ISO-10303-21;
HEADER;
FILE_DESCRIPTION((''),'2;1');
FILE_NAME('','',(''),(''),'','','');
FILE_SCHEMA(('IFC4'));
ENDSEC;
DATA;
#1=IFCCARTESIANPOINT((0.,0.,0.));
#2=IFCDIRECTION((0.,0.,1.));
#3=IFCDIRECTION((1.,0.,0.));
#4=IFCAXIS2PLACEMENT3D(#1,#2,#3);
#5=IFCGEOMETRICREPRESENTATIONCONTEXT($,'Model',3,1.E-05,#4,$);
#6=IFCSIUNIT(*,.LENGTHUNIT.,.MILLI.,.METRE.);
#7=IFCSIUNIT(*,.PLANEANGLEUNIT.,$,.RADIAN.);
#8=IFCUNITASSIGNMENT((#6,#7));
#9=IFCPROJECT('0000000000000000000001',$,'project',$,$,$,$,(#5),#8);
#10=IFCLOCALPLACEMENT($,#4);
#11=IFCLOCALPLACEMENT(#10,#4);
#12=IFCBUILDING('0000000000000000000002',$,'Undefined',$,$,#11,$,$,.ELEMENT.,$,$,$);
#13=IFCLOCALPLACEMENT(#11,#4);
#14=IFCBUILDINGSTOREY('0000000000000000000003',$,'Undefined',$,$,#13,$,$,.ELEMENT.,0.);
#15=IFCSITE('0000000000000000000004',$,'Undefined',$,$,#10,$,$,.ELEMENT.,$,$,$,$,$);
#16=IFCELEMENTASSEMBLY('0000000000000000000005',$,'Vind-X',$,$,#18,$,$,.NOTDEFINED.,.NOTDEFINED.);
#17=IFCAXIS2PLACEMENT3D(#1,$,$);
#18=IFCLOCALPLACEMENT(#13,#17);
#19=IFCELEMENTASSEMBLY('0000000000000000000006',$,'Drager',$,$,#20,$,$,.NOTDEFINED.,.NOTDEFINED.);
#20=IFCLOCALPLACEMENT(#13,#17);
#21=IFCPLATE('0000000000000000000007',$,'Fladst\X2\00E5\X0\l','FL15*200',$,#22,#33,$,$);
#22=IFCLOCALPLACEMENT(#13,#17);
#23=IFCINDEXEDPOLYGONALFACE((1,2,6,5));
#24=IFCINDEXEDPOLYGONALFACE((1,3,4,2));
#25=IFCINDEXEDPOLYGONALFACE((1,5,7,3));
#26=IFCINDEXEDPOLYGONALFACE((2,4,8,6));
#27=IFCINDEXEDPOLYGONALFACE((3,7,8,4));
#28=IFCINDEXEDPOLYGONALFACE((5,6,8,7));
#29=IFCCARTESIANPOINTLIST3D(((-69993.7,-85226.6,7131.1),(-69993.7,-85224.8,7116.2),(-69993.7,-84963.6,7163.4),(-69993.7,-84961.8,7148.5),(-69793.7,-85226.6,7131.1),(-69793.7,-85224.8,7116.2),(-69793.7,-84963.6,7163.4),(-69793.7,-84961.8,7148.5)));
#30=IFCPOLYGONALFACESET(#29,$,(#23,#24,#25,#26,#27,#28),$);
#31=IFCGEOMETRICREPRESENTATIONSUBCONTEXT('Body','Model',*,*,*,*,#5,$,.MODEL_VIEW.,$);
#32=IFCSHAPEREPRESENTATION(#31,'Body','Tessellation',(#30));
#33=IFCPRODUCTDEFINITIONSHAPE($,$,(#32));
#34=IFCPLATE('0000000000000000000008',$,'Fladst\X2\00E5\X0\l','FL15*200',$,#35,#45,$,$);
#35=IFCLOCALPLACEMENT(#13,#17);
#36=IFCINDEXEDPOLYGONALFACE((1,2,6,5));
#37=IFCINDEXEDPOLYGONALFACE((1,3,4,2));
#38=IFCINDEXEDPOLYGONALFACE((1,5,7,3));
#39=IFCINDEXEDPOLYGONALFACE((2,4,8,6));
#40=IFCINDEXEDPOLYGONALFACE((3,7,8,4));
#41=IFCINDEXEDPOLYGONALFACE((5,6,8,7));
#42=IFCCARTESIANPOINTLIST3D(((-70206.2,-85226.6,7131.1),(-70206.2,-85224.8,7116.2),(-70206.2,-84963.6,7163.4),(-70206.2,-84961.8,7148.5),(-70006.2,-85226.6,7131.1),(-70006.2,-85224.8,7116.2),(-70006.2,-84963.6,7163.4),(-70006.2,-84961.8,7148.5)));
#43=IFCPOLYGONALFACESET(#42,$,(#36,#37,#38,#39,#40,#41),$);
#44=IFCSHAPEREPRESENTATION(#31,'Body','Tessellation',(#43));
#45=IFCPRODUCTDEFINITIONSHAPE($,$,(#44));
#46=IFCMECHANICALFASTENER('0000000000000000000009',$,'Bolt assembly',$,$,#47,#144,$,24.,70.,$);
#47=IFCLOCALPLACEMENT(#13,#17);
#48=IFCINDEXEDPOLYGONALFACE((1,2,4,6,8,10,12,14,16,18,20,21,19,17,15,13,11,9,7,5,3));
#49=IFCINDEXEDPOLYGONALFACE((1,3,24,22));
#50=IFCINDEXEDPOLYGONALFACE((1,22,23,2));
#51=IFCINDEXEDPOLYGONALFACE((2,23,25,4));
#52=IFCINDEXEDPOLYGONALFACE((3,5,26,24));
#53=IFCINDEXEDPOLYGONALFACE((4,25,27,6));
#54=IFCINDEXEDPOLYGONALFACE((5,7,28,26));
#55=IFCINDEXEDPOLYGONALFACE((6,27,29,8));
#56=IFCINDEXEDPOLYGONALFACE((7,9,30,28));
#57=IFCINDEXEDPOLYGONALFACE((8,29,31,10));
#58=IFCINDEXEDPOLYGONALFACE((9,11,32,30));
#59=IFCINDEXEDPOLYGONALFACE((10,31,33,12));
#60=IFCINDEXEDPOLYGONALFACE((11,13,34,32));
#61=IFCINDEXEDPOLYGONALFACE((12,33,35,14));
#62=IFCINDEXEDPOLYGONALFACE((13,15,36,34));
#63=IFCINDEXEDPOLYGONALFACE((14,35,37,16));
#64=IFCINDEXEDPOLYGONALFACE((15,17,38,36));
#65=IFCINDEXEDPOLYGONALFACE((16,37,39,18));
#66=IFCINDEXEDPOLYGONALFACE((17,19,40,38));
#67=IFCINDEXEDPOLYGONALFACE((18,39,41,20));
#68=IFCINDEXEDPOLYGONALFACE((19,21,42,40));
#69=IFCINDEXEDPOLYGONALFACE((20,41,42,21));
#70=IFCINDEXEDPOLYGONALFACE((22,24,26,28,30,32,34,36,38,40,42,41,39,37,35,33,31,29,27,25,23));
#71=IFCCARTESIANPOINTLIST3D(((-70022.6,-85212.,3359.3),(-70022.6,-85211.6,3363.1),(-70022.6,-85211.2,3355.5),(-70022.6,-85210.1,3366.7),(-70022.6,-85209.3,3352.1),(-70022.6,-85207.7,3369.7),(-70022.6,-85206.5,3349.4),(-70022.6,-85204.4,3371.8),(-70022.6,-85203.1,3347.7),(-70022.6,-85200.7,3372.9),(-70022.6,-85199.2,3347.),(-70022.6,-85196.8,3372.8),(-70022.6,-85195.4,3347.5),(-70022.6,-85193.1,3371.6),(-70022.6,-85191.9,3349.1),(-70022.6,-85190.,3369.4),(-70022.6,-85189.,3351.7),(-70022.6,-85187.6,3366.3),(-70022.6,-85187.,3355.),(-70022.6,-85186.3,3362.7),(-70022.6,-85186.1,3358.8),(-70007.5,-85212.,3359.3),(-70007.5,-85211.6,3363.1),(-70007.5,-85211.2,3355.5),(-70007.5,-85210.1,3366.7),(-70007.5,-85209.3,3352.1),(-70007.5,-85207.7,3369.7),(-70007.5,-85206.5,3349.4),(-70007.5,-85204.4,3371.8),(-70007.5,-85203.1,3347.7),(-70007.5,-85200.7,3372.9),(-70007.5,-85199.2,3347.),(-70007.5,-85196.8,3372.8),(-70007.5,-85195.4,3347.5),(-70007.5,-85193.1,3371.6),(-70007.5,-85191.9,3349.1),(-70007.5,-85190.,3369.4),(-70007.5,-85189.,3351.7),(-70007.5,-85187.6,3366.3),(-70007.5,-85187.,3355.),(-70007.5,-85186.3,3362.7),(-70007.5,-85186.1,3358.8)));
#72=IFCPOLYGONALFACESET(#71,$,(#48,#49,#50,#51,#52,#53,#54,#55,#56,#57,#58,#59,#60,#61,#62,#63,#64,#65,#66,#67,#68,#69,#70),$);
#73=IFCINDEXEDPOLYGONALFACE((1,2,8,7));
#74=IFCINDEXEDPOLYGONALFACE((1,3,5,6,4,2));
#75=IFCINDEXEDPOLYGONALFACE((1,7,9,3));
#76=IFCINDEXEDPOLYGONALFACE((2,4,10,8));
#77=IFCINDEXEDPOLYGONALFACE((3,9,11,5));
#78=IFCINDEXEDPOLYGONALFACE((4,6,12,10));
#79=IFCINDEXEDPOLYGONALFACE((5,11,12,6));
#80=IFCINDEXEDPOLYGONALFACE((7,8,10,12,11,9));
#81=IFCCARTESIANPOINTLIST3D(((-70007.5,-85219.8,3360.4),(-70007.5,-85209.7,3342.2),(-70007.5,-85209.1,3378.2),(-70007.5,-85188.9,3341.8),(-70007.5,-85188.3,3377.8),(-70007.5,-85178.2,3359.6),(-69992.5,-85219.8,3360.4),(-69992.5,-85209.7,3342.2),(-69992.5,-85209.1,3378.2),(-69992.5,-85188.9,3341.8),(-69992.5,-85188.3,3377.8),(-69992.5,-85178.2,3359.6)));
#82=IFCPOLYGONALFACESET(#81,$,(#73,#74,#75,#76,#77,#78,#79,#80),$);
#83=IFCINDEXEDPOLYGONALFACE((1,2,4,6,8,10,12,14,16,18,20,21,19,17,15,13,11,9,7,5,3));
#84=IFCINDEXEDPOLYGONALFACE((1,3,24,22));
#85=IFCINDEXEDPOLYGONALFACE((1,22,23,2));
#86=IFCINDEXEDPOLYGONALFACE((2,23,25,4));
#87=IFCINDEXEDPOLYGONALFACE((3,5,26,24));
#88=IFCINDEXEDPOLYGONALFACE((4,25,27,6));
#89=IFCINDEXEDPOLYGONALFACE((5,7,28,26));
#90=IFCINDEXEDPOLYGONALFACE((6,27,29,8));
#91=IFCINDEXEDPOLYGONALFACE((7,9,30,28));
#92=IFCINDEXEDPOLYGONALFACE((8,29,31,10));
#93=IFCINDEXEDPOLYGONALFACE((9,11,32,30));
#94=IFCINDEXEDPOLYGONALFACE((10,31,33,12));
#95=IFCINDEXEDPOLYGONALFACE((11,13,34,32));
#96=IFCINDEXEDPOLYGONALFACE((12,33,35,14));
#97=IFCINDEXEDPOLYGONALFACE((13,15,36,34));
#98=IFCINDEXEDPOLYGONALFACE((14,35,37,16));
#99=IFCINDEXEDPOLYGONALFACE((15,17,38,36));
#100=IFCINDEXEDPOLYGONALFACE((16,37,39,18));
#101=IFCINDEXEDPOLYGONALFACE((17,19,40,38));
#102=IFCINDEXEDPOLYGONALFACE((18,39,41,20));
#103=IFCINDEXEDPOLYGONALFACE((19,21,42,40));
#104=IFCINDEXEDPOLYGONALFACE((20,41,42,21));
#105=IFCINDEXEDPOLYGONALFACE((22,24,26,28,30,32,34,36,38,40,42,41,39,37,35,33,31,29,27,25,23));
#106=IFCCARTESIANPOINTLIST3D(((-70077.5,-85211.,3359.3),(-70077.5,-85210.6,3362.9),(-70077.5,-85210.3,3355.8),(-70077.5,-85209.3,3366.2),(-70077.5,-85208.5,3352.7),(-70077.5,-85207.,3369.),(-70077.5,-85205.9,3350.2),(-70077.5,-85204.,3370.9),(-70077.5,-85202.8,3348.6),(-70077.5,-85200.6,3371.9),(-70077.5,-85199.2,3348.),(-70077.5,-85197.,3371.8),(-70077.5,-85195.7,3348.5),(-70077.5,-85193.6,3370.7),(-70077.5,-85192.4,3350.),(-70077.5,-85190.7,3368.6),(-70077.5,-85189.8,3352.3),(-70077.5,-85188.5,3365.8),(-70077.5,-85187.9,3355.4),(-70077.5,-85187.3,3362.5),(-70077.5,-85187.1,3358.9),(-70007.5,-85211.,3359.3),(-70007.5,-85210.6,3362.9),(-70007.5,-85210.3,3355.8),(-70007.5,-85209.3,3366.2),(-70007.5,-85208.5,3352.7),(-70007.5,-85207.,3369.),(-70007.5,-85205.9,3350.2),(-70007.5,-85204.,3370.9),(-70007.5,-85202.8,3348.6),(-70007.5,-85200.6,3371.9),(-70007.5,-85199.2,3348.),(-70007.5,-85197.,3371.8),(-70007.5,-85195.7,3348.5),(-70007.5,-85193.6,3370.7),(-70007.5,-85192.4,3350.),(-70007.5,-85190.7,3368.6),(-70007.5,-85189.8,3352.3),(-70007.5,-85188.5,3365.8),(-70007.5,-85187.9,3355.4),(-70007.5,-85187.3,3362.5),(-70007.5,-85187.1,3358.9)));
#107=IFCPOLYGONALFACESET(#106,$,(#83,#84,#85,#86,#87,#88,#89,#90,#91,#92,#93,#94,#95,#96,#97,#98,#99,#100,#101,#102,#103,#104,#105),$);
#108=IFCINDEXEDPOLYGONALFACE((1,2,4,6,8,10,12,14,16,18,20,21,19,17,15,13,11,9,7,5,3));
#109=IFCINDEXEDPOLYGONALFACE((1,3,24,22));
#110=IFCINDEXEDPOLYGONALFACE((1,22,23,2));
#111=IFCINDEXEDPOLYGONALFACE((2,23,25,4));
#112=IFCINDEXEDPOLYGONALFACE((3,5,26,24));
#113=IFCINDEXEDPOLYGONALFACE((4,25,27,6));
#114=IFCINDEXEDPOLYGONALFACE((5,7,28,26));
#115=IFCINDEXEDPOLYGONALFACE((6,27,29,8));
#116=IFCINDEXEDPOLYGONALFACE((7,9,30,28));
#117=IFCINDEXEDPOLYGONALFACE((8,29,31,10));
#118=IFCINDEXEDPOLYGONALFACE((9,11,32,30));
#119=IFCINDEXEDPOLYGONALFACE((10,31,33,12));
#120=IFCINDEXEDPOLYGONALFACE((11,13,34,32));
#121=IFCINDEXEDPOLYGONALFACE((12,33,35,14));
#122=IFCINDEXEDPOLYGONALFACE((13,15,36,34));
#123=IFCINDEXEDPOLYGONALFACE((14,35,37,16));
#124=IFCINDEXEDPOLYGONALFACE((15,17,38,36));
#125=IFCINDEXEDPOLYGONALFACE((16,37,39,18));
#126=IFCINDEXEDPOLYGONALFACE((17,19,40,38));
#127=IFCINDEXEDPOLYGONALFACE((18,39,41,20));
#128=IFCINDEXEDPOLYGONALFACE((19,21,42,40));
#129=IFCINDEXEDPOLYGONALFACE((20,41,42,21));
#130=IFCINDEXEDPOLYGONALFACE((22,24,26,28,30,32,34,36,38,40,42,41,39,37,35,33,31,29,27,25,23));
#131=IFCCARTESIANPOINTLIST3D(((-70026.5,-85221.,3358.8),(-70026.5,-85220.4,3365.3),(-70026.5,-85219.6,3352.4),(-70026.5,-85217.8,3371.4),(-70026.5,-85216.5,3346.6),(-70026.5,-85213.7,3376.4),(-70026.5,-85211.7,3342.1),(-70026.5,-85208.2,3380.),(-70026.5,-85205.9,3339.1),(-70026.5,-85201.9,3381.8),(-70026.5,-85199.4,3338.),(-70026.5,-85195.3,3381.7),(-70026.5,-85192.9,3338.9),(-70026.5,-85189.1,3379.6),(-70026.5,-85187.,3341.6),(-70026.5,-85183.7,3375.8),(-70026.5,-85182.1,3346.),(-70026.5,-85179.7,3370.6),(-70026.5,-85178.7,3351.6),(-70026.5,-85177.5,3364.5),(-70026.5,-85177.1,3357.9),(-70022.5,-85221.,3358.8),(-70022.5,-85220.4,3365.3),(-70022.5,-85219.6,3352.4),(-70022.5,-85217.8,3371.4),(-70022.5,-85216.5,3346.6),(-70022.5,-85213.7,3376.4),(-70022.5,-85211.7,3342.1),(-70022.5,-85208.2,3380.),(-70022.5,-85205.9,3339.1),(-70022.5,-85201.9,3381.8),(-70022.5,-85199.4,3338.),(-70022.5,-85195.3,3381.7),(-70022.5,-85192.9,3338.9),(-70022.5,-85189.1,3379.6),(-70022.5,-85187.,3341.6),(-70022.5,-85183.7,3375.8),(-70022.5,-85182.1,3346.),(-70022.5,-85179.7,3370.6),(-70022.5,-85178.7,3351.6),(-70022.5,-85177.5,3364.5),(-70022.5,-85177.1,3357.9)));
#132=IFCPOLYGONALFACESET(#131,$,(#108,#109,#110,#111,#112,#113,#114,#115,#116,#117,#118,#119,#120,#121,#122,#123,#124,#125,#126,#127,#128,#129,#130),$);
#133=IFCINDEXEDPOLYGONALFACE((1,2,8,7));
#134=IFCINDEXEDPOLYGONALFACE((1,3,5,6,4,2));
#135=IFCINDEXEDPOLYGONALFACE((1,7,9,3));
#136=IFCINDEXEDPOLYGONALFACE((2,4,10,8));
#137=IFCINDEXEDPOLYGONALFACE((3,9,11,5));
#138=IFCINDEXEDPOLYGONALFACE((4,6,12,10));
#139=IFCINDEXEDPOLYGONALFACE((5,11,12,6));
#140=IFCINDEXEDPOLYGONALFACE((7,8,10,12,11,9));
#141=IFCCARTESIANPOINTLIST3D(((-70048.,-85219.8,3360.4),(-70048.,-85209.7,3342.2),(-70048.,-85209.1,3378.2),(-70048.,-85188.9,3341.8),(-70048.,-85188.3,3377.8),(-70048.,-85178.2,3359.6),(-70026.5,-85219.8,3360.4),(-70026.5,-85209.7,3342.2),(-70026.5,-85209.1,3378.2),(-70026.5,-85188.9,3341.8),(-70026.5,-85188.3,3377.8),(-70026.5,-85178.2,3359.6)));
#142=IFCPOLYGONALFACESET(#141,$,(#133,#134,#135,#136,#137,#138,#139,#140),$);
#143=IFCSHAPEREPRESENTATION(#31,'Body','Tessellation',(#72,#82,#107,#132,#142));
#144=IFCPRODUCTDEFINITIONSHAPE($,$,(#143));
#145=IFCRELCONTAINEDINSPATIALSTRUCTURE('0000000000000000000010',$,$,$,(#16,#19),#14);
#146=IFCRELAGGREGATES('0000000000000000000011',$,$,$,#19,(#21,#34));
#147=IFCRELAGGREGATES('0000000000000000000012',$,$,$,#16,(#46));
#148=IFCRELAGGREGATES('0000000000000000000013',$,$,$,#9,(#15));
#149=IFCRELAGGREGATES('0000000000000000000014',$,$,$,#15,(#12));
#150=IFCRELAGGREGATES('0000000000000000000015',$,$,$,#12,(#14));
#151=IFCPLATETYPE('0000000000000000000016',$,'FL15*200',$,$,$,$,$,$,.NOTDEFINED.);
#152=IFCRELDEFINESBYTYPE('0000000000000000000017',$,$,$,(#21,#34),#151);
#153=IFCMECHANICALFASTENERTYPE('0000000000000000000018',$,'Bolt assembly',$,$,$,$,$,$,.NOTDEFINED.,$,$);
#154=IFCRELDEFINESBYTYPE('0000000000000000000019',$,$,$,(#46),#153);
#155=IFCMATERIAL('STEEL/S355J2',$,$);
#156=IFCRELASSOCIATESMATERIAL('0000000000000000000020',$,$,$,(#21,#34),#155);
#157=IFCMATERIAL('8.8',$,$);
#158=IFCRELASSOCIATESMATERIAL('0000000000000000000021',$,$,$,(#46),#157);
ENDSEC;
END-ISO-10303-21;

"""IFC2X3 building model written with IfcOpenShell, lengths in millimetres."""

from ifc_helpers import new_model, si_unit, frame, origin_with_axes, origin_2d_with_axis, place, context, subcontext, project, spatial, polyline, circle, outline, extrude, source, transform, mapped, material, type_object, element, aggregate, save


model = new_model("IFC2X3")

# Units and contexts
model_context = context("Model", 3, precision=1e-05, world=origin_with_axes())
body_context = subcontext(model_context, "Body", "Model", "MODEL_VIEW")
ifc_project = project(units=[si_unit("LENGTHUNIT", "METRE", prefix="MILLI"), si_unit("PLANEANGLEUNIT", "RADIAN")], contexts=[model_context])

# Site, building, storey
site_placement = place(None, origin_with_axes())
site = spatial("IfcSite", under=ifc_project, at=site_placement, Name="Undefined", CompositionType="ELEMENT")
building_placement = place(site_placement, origin_with_axes())
building = spatial("IfcBuilding", under=site, at=building_placement, Name="Undefined", CompositionType="ELEMENT")
storey_placement = place(building_placement, origin_with_axes())
storey = spatial("IfcBuildingStorey", under=building, at=storey_placement, Name="Undefined", CompositionType="ELEMENT", Elevation=0.0)

# Element assembly
assembly_1_placement = place(storey_placement, origin_with_axes())
assembly_1 = element("IfcElementAssembly", 1, at=assembly_1_placement, inside=storey, Name="Vind-X", AssemblyPlace="NOTDEFINED", PredefinedType="NOTDEFINED")
ifc_material_1 = material(Name="STEEL/S355J2")

# Element assembly
assembly_2_placement = place(storey_placement, origin_with_axes())
assembly_2 = element("IfcElementAssembly", 2, at=assembly_2_placement, inside=storey, Name="Drager", AssemblyPlace="NOTDEFINED", PredefinedType="NOTDEFINED")

# Plates
plate_type_1 = type_object("IfcPlateType", Name="FL15*200", PredefinedType="NOTDEFINED")
plate_1_placement = place(assembly_2_placement, frame((-69993.7, -84962.7, 7155.9), z_axis=(0.0, -0.121869, 0.992546), x_axis=(0.0, -0.992546, -0.121869)))
plate_1 = element("IfcPlate", 3, at=plate_1_placement, type_object=plate_type_1, material=ifc_material_1, Name="Fladstål", Description="FL15*200", context=body_context, shape_type="SweptSolid", body=[
    extrude(outline(polyline([(0.0, 0.0), (265.0, 0.0), (265.0, 200.0), (0.0, 200.0), (0.0, 0.0)])), frame((0.0, 0.0, -7.5), z_axis=(0.0, 0.0, 1.0), x_axis=(1.0, 0.0, 0.0)), (0.0, 0.0, 1.0), 15.0),
])
plate_2_placement = place(assembly_2_placement, frame((-70006.2, -85225.7, 7123.6), z_axis=(0.0, -0.121869, 0.992546), x_axis=(0.0, 0.992546, 0.121869)))
plate_2 = element("IfcPlate", 4, at=plate_2_placement, type_object=plate_type_1, material=ifc_material_1, Name="Fladstål", Description="FL15*200", context=body_context, shape_type="SweptSolid", body=[
    extrude(outline(polyline([(0.0, 0.0), (265.0, 0.0), (265.0, 200.0), (0.0, 200.0), (0.0, 0.0)])), frame((0.0, 0.0, -7.5), z_axis=(0.0, 0.0, 1.0), x_axis=(1.0, 0.0, 0.0)), (0.0, 0.0, 1.0), 15.0),
])
aggregate(assembly_2, [plate_1, plate_2])

# Mechanical fastener
ifc_material_2 = material(Name="8.8")
mechanical_fastener_type = type_object("IfcMechanicalFastenerType", Name="Bolt assembly")
shared_shape_1 = source(origin_with_axes(), body_context, "Body", "SweptSolid", [
    extrude(circle(Radius=13.0, at=origin_2d_with_axis()), frame((0.0, 0.0, 0.0), z_axis=(0.0, 1.0, 0.0), x_axis=(1.0, 0.0, 0.0)), (0.0, 0.0, 1.0), 15.1),
    extrude(outline(polyline([(18.0, -10.4), (18.0, 10.4), (0.0, 20.8), (-18.0, 10.4), (-18.0, -10.4), (0.0, -20.8), (18.0, -10.4)])), frame((0.0, -15.0, 0.0), z_axis=(0.0, 1.0, 0.0), x_axis=(1.0, 0.0, 0.0)), (0.0, 0.0, 1.0), 15.0),
    extrude(circle(Radius=12.0, at=origin_2d_with_axis()), frame((0.0, 0.0, 0.0), z_axis=(0.0, 1.0, 0.0), x_axis=(1.0, 0.0, 0.0)), (0.0, 0.0, 1.0), 70.0),
    extrude(circle(Radius=22.0, at=origin_2d_with_axis()), frame((0.0, 15.0, 0.0), z_axis=(0.0, 1.0, 0.0), x_axis=(1.0, 0.0, 0.0)), (0.0, 0.0, 1.0), 4.0),
    extrude(outline(polyline([(18.0, -10.4), (18.0, 10.4), (0.0, 20.8), (-18.0, 10.4), (-18.0, -10.4), (0.0, -20.8), (18.0, -10.4)])), frame((0.0, 19.0, 0.0), z_axis=(0.0, 1.0, 0.0), x_axis=(1.0, 0.0, 0.0)), (0.0, 0.0, 1.0), 21.5),
])
mechanical_fastener_1_placement = place(assembly_1_placement, frame((-70007.5, -85199.0, 3360.0), z_axis=(0.0, -0.516247, -0.85644), x_axis=(0.0, -0.85644, 0.516247)))
mechanical_fastener_1 = element("IfcMechanicalFastener", 5, at=mechanical_fastener_1_placement, type_object=mechanical_fastener_type, material=ifc_material_2, Name="Bolt assembly", NominalDiameter=24.0, NominalLength=70.0, context=body_context, shape_type="MappedRepresentation", body=[
    mapped(shared_shape_1, transform((0.0, 0.0, 0.0))),
])
aggregate(assembly_1, [mechanical_fastener_1])

save(model, "model.ifc")
